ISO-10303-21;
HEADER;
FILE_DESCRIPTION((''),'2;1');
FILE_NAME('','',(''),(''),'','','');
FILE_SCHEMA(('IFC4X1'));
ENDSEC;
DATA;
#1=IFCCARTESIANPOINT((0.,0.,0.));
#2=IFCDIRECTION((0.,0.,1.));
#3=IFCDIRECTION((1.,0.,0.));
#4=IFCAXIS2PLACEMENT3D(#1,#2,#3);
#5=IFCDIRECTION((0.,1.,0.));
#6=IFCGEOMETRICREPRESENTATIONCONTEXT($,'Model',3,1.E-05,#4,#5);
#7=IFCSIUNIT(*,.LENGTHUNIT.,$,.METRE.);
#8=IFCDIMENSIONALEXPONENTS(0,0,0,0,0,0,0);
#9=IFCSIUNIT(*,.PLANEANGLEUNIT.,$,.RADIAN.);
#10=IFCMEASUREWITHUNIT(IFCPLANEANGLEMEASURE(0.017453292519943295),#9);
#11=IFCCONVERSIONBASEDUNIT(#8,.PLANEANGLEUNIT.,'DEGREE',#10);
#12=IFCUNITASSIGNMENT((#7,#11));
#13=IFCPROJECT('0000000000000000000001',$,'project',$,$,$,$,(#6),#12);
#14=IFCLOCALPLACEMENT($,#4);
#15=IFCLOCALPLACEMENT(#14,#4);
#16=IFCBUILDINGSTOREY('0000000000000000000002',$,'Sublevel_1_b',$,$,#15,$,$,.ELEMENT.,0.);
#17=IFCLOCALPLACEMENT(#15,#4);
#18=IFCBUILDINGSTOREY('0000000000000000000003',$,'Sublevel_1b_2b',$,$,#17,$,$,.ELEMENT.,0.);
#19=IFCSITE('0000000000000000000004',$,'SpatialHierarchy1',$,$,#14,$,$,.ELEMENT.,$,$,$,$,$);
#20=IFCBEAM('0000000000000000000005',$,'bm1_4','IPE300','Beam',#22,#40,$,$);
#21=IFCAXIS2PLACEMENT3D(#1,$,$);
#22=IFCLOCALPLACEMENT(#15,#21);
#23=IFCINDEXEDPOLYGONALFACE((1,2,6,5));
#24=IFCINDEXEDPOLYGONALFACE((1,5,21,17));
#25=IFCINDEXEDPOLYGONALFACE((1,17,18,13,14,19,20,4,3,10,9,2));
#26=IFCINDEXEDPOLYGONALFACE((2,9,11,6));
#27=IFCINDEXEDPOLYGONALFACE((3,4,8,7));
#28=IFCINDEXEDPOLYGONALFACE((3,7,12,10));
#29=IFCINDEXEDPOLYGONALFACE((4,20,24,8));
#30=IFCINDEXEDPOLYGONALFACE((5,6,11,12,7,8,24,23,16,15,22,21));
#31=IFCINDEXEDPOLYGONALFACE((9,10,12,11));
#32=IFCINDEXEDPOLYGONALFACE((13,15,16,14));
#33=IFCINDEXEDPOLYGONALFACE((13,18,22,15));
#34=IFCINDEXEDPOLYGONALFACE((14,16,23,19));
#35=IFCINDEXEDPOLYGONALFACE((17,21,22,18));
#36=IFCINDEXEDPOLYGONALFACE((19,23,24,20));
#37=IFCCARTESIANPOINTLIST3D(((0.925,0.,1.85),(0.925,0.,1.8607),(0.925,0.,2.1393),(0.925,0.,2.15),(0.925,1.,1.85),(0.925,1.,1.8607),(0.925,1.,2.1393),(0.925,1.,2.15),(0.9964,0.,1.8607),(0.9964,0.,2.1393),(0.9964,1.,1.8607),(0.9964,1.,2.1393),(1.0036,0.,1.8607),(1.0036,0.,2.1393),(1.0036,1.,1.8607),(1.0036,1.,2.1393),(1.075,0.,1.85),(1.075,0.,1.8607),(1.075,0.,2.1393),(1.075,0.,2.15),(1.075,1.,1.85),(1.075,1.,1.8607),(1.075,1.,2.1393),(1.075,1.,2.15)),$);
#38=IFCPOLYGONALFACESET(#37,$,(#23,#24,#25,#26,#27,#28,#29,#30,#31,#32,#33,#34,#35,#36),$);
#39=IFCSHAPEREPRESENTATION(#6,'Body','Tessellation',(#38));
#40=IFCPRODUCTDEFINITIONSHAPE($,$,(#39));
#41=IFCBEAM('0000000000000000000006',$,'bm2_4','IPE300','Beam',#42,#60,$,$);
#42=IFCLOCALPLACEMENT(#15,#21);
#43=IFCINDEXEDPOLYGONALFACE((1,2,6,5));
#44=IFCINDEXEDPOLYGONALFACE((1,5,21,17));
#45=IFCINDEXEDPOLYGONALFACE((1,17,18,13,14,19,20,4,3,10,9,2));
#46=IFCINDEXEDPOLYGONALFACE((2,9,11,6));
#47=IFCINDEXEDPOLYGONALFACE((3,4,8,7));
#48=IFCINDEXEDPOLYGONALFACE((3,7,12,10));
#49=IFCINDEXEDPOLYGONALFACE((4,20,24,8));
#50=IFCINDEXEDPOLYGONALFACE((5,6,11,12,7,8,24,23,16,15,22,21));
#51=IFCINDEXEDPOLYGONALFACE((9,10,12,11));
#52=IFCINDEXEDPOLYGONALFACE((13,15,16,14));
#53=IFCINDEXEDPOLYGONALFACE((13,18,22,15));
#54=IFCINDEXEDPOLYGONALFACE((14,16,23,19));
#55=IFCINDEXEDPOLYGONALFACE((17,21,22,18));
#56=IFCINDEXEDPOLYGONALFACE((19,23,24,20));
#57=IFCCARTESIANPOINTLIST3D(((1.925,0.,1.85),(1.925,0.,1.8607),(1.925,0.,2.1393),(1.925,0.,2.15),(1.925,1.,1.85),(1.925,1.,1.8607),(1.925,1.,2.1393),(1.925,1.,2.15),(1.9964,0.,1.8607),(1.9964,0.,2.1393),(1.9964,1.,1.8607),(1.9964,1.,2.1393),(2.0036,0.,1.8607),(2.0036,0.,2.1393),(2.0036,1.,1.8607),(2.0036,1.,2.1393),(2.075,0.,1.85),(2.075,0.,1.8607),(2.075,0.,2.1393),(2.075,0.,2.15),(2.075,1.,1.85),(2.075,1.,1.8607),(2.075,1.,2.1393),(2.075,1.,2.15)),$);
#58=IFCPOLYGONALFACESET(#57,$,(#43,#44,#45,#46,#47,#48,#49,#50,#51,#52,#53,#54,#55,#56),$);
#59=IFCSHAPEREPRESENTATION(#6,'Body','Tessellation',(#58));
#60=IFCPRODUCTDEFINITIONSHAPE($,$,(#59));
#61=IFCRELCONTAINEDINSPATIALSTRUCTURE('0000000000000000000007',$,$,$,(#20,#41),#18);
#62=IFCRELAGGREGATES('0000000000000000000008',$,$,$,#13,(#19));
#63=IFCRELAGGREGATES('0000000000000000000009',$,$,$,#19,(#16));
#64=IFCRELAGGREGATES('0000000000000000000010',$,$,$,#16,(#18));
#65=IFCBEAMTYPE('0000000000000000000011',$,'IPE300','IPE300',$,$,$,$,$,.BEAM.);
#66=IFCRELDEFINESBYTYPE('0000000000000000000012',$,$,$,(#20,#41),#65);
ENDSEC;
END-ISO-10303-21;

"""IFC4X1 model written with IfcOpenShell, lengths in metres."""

from ifc_helpers import new_model, entity, si_unit, converted_unit, direction, frame, origin, origin_with_axes, place, context, project, spatial, i_section, extrude, type_object, element, save


model = new_model("IFC4X1")

# Units and contexts
model_context = context("Model", 3, precision=1e-05, world=origin_with_axes(), true_north=direction((0.0, 1.0, 0.0)))
ifc_project = project(units=[si_unit("LENGTHUNIT", "METRE"), converted_unit("PLANEANGLEUNIT", "DEGREE", entity("IfcPlaneAngleMeasure", 0.017453292519943295), si_unit("PLANEANGLEUNIT", "RADIAN"), dimensions=[0, 0, 0, 0, 0, 0, 0])], contexts=[model_context])

# Site, storeys
site_placement = place(None, origin_with_axes())
site = spatial("IfcSite", under=ifc_project, at=site_placement, Name="SpatialHierarchy1", CompositionType="ELEMENT")
storey_1_placement = place(site_placement, origin_with_axes())
storey_1 = spatial("IfcBuildingStorey", under=site, at=storey_1_placement, Name="Sublevel_1_b", CompositionType="ELEMENT", Elevation=0.0)
storey_2_placement = place(storey_1_placement, origin_with_axes())
storey_2 = spatial("IfcBuildingStorey", under=storey_1, at=storey_2_placement, Name="Sublevel_1b_2b", CompositionType="ELEMENT", Elevation=0.0)

# Beams
beam_type = type_object("IfcBeamType", Name="IPE300", Description="IPE300", PredefinedType="BEAM")
placement_1 = place(storey_2_placement, origin_with_axes())
beam_1_placement = place(placement_1, frame((1.0, 0.0, 2.0), z_axis=(0.0, 1.0, 0.0), x_axis=(-1.0, 0.0, 0.0)))
element("IfcBeam", 1, at=beam_1_placement, inside=storey_2, type_object=beam_type, Name="bm1_4", Description="IPE300", ObjectType="Beam", context=model_context, shape_type="SweptSolid", body=[
    extrude(i_section(OverallWidth=0.15, OverallDepth=0.3, WebThickness=0.0071, FlangeThickness=0.0107), origin(), (0.0, 0.0, 1.0), 1.0),
])
placement_2 = place(storey_2_placement, origin_with_axes())
beam_2_placement = place(placement_2, frame((2.0, 0.0, 2.0), z_axis=(0.0, 1.0, 0.0), x_axis=(-1.0, 0.0, 0.0)))
element("IfcBeam", 2, at=beam_2_placement, inside=storey_2, type_object=beam_type, Name="bm2_4", Description="IPE300", ObjectType="Beam", context=model_context, shape_type="SweptSolid", body=[
    extrude(i_section(OverallWidth=0.15, OverallDepth=0.3, WebThickness=0.0071, FlangeThickness=0.0107), origin(), (0.0, 0.0, 1.0), 1.0),
])

save(model, "model.ifc")
